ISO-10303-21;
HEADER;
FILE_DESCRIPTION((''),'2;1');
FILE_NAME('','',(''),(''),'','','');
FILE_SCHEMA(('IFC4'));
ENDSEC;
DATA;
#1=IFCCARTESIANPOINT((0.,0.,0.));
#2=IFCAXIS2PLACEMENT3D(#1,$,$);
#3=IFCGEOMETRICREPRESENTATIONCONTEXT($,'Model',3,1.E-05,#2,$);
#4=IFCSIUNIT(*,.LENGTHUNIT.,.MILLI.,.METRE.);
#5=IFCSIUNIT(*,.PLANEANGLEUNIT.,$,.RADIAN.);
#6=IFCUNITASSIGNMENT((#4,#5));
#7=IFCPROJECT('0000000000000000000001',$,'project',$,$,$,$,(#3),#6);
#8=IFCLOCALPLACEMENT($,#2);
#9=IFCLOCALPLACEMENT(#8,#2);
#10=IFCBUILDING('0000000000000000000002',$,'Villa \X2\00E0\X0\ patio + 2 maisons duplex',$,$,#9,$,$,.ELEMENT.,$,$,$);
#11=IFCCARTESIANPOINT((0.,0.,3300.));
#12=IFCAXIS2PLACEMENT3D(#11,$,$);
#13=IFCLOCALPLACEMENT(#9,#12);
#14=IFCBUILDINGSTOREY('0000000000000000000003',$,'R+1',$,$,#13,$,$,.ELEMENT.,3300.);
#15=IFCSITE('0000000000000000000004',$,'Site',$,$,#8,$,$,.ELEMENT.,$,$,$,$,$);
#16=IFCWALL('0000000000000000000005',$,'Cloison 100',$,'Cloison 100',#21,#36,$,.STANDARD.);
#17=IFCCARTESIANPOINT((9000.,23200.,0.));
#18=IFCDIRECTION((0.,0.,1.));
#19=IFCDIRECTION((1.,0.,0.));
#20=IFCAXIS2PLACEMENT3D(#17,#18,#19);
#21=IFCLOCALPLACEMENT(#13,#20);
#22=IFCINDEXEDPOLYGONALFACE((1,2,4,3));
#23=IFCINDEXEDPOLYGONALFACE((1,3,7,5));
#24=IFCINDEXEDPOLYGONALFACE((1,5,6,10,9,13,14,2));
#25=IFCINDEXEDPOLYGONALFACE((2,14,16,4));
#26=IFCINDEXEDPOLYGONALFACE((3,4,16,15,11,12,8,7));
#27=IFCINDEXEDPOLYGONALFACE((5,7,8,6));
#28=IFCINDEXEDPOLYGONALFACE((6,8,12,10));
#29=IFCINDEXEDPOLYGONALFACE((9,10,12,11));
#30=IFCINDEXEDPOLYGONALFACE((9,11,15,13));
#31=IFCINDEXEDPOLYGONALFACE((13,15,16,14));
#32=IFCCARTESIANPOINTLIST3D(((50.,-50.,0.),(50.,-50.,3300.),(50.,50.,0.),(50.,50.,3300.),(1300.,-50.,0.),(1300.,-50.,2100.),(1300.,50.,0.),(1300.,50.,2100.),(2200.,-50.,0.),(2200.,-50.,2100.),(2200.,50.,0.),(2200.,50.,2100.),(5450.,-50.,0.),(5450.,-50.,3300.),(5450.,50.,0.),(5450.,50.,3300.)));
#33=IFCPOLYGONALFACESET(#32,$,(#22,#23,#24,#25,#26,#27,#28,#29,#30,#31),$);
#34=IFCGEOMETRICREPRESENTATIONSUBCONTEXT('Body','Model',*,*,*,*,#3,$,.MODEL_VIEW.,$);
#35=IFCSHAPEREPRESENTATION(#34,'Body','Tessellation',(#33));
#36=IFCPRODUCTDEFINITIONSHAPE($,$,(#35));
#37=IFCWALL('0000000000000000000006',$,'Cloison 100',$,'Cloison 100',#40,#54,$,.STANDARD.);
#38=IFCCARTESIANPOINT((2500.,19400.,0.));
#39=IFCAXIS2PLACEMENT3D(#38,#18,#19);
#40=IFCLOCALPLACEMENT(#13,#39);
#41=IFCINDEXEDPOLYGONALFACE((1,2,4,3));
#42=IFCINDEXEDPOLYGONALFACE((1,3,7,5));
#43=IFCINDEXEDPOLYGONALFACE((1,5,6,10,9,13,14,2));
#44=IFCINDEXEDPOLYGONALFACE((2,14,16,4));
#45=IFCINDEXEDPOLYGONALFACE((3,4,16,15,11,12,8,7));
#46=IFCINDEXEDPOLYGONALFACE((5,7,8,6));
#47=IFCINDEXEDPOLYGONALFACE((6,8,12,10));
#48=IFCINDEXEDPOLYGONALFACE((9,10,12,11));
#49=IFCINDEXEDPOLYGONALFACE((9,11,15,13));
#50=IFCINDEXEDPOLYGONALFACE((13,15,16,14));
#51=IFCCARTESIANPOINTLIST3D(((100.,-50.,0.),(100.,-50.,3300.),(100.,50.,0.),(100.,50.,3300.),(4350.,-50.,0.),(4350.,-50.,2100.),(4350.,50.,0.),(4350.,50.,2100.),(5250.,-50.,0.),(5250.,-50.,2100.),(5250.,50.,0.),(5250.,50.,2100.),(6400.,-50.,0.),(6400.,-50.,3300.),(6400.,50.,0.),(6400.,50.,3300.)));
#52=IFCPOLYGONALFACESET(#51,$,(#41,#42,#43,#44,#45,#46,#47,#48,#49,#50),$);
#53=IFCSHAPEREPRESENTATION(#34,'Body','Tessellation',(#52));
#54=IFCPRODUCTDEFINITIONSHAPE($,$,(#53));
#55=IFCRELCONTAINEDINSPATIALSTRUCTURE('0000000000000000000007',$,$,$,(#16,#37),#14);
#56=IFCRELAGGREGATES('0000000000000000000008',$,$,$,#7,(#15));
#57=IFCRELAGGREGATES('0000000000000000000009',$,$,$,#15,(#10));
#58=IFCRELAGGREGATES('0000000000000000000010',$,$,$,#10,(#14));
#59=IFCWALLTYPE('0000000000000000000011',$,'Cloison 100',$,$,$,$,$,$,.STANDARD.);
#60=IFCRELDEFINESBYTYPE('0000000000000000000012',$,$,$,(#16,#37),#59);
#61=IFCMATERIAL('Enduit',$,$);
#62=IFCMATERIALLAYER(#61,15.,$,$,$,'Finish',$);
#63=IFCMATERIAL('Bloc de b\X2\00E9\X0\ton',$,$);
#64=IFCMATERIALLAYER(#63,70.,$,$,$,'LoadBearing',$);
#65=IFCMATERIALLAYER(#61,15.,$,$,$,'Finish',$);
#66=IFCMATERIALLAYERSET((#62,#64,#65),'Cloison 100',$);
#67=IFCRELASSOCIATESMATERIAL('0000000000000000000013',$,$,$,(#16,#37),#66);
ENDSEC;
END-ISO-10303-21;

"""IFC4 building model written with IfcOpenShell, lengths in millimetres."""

from ifc_helpers import new_model, si_unit, frame, frame_2d, origin, place, context, subcontext, project, spatial, polyline, rectangle, outline, extrude, material, layer, layer_set, layer_usage, type_object, element, save


model = new_model("IFC4")

# Units and contexts
model_context = context("Model", 3, precision=1e-05, world=origin())
body_context = subcontext(model_context, "Body", "Model", "MODEL_VIEW")
ifc_project = project(units=[si_unit("LENGTHUNIT", "METRE", prefix="MILLI"), si_unit("PLANEANGLEUNIT", "RADIAN")], contexts=[model_context])

# Site, building, storey
site_placement = place(None, origin())
site = spatial("IfcSite", under=ifc_project, at=site_placement, Name="Site", CompositionType="ELEMENT")
building_placement = place(site_placement, origin())
building = spatial("IfcBuilding", under=site, at=building_placement, Name="Villa à patio + 2 maisons duplex", CompositionType="ELEMENT")
storey_placement = place(building_placement, frame((0.0, 0.0, 3300.0)))
storey = spatial("IfcBuildingStorey", under=building, at=storey_placement, Name="R+1", CompositionType="ELEMENT", Elevation=3300.0)

# Shared definitions
ifc_material_1 = material(Name="Enduit")
ifc_layer_1 = layer(ifc_material_1, 15.0, Category="Finish")
ifc_material_2 = material(Name="Bloc de béton")
ifc_layer_2 = layer(ifc_material_2, 70.0, Category="LoadBearing")
ifc_layer_3 = layer(ifc_material_1, 15.0, Category="Finish")
ifc_layer_set_1 = layer_set([ifc_layer_1, ifc_layer_2, ifc_layer_3], Name="Cloison 100")
ifc_layer_usage_1 = layer_usage(ifc_layer_set_1, "AXIS2", "NEGATIVE", 50.0)
wall_type_1 = type_object("IfcWallType", Name="Cloison 100", PredefinedType="STANDARD")

# Walls, openings
wall_1_placement = place(storey_placement, frame((9000.0, 23200.0, 0.0), z_axis=(0.0, 0.0, 1.0), x_axis=(1.0, 0.0, 0.0)))
wall_1 = element("IfcWall", 1, at=wall_1_placement, inside=storey, type_object=wall_type_1, material=ifc_layer_usage_1, Name="Cloison 100", ObjectType="Cloison 100", PredefinedType="STANDARD", context=body_context, shape_type="SweptSolid", body=[
    extrude(outline(polyline([(50.0, -50.0), (50.0, 50.0), (5450.0, 50.0), (5450.0, -50.0), (50.0, -50.0)])), origin(), (0.0, 0.0, 1.0), 3300.0),
])
opening_1_placement = place(wall_1_placement, frame((1300.0, 0.0, 0.0), z_axis=(0.0, 0.0, 1.0), x_axis=(1.0, 0.0, 0.0)))
element("IfcOpeningElement", 2, at=opening_1_placement, cuts=wall_1, PredefinedType="OPENING", context=body_context, shape_type="SweptSolid", body=[
    extrude(rectangle(XDim=900.0, YDim=120.0, at=frame_2d((450.0, 0.0))), origin(), (0.0, 0.0, 1.0), 2100.0),
])
wall_2_placement = place(storey_placement, frame((2500.0, 19400.0, 0.0), z_axis=(0.0, 0.0, 1.0), x_axis=(1.0, 0.0, 0.0)))
wall_2 = element("IfcWall", 3, at=wall_2_placement, inside=storey, type_object=wall_type_1, material=ifc_layer_usage_1, Name="Cloison 100", ObjectType="Cloison 100", PredefinedType="STANDARD", context=body_context, shape_type="SweptSolid", body=[
    extrude(outline(polyline([(100.0, -50.0), (100.0, 50.0), (6400.0, 50.0), (6400.0, -50.0), (100.0, -50.0)])), origin(), (0.0, 0.0, 1.0), 3300.0),
])
opening_2_placement = place(wall_2_placement, frame((4350.0, 0.0, 0.0), z_axis=(0.0, 0.0, 1.0), x_axis=(1.0, 0.0, 0.0)))
element("IfcOpeningElement", 4, at=opening_2_placement, cuts=wall_2, PredefinedType="OPENING", context=body_context, shape_type="SweptSolid", body=[
    extrude(rectangle(XDim=900.0, YDim=120.0, at=frame_2d((450.0, 0.0))), origin(), (0.0, 0.0, 1.0), 2100.0),
])

save(model, "model.ifc")
